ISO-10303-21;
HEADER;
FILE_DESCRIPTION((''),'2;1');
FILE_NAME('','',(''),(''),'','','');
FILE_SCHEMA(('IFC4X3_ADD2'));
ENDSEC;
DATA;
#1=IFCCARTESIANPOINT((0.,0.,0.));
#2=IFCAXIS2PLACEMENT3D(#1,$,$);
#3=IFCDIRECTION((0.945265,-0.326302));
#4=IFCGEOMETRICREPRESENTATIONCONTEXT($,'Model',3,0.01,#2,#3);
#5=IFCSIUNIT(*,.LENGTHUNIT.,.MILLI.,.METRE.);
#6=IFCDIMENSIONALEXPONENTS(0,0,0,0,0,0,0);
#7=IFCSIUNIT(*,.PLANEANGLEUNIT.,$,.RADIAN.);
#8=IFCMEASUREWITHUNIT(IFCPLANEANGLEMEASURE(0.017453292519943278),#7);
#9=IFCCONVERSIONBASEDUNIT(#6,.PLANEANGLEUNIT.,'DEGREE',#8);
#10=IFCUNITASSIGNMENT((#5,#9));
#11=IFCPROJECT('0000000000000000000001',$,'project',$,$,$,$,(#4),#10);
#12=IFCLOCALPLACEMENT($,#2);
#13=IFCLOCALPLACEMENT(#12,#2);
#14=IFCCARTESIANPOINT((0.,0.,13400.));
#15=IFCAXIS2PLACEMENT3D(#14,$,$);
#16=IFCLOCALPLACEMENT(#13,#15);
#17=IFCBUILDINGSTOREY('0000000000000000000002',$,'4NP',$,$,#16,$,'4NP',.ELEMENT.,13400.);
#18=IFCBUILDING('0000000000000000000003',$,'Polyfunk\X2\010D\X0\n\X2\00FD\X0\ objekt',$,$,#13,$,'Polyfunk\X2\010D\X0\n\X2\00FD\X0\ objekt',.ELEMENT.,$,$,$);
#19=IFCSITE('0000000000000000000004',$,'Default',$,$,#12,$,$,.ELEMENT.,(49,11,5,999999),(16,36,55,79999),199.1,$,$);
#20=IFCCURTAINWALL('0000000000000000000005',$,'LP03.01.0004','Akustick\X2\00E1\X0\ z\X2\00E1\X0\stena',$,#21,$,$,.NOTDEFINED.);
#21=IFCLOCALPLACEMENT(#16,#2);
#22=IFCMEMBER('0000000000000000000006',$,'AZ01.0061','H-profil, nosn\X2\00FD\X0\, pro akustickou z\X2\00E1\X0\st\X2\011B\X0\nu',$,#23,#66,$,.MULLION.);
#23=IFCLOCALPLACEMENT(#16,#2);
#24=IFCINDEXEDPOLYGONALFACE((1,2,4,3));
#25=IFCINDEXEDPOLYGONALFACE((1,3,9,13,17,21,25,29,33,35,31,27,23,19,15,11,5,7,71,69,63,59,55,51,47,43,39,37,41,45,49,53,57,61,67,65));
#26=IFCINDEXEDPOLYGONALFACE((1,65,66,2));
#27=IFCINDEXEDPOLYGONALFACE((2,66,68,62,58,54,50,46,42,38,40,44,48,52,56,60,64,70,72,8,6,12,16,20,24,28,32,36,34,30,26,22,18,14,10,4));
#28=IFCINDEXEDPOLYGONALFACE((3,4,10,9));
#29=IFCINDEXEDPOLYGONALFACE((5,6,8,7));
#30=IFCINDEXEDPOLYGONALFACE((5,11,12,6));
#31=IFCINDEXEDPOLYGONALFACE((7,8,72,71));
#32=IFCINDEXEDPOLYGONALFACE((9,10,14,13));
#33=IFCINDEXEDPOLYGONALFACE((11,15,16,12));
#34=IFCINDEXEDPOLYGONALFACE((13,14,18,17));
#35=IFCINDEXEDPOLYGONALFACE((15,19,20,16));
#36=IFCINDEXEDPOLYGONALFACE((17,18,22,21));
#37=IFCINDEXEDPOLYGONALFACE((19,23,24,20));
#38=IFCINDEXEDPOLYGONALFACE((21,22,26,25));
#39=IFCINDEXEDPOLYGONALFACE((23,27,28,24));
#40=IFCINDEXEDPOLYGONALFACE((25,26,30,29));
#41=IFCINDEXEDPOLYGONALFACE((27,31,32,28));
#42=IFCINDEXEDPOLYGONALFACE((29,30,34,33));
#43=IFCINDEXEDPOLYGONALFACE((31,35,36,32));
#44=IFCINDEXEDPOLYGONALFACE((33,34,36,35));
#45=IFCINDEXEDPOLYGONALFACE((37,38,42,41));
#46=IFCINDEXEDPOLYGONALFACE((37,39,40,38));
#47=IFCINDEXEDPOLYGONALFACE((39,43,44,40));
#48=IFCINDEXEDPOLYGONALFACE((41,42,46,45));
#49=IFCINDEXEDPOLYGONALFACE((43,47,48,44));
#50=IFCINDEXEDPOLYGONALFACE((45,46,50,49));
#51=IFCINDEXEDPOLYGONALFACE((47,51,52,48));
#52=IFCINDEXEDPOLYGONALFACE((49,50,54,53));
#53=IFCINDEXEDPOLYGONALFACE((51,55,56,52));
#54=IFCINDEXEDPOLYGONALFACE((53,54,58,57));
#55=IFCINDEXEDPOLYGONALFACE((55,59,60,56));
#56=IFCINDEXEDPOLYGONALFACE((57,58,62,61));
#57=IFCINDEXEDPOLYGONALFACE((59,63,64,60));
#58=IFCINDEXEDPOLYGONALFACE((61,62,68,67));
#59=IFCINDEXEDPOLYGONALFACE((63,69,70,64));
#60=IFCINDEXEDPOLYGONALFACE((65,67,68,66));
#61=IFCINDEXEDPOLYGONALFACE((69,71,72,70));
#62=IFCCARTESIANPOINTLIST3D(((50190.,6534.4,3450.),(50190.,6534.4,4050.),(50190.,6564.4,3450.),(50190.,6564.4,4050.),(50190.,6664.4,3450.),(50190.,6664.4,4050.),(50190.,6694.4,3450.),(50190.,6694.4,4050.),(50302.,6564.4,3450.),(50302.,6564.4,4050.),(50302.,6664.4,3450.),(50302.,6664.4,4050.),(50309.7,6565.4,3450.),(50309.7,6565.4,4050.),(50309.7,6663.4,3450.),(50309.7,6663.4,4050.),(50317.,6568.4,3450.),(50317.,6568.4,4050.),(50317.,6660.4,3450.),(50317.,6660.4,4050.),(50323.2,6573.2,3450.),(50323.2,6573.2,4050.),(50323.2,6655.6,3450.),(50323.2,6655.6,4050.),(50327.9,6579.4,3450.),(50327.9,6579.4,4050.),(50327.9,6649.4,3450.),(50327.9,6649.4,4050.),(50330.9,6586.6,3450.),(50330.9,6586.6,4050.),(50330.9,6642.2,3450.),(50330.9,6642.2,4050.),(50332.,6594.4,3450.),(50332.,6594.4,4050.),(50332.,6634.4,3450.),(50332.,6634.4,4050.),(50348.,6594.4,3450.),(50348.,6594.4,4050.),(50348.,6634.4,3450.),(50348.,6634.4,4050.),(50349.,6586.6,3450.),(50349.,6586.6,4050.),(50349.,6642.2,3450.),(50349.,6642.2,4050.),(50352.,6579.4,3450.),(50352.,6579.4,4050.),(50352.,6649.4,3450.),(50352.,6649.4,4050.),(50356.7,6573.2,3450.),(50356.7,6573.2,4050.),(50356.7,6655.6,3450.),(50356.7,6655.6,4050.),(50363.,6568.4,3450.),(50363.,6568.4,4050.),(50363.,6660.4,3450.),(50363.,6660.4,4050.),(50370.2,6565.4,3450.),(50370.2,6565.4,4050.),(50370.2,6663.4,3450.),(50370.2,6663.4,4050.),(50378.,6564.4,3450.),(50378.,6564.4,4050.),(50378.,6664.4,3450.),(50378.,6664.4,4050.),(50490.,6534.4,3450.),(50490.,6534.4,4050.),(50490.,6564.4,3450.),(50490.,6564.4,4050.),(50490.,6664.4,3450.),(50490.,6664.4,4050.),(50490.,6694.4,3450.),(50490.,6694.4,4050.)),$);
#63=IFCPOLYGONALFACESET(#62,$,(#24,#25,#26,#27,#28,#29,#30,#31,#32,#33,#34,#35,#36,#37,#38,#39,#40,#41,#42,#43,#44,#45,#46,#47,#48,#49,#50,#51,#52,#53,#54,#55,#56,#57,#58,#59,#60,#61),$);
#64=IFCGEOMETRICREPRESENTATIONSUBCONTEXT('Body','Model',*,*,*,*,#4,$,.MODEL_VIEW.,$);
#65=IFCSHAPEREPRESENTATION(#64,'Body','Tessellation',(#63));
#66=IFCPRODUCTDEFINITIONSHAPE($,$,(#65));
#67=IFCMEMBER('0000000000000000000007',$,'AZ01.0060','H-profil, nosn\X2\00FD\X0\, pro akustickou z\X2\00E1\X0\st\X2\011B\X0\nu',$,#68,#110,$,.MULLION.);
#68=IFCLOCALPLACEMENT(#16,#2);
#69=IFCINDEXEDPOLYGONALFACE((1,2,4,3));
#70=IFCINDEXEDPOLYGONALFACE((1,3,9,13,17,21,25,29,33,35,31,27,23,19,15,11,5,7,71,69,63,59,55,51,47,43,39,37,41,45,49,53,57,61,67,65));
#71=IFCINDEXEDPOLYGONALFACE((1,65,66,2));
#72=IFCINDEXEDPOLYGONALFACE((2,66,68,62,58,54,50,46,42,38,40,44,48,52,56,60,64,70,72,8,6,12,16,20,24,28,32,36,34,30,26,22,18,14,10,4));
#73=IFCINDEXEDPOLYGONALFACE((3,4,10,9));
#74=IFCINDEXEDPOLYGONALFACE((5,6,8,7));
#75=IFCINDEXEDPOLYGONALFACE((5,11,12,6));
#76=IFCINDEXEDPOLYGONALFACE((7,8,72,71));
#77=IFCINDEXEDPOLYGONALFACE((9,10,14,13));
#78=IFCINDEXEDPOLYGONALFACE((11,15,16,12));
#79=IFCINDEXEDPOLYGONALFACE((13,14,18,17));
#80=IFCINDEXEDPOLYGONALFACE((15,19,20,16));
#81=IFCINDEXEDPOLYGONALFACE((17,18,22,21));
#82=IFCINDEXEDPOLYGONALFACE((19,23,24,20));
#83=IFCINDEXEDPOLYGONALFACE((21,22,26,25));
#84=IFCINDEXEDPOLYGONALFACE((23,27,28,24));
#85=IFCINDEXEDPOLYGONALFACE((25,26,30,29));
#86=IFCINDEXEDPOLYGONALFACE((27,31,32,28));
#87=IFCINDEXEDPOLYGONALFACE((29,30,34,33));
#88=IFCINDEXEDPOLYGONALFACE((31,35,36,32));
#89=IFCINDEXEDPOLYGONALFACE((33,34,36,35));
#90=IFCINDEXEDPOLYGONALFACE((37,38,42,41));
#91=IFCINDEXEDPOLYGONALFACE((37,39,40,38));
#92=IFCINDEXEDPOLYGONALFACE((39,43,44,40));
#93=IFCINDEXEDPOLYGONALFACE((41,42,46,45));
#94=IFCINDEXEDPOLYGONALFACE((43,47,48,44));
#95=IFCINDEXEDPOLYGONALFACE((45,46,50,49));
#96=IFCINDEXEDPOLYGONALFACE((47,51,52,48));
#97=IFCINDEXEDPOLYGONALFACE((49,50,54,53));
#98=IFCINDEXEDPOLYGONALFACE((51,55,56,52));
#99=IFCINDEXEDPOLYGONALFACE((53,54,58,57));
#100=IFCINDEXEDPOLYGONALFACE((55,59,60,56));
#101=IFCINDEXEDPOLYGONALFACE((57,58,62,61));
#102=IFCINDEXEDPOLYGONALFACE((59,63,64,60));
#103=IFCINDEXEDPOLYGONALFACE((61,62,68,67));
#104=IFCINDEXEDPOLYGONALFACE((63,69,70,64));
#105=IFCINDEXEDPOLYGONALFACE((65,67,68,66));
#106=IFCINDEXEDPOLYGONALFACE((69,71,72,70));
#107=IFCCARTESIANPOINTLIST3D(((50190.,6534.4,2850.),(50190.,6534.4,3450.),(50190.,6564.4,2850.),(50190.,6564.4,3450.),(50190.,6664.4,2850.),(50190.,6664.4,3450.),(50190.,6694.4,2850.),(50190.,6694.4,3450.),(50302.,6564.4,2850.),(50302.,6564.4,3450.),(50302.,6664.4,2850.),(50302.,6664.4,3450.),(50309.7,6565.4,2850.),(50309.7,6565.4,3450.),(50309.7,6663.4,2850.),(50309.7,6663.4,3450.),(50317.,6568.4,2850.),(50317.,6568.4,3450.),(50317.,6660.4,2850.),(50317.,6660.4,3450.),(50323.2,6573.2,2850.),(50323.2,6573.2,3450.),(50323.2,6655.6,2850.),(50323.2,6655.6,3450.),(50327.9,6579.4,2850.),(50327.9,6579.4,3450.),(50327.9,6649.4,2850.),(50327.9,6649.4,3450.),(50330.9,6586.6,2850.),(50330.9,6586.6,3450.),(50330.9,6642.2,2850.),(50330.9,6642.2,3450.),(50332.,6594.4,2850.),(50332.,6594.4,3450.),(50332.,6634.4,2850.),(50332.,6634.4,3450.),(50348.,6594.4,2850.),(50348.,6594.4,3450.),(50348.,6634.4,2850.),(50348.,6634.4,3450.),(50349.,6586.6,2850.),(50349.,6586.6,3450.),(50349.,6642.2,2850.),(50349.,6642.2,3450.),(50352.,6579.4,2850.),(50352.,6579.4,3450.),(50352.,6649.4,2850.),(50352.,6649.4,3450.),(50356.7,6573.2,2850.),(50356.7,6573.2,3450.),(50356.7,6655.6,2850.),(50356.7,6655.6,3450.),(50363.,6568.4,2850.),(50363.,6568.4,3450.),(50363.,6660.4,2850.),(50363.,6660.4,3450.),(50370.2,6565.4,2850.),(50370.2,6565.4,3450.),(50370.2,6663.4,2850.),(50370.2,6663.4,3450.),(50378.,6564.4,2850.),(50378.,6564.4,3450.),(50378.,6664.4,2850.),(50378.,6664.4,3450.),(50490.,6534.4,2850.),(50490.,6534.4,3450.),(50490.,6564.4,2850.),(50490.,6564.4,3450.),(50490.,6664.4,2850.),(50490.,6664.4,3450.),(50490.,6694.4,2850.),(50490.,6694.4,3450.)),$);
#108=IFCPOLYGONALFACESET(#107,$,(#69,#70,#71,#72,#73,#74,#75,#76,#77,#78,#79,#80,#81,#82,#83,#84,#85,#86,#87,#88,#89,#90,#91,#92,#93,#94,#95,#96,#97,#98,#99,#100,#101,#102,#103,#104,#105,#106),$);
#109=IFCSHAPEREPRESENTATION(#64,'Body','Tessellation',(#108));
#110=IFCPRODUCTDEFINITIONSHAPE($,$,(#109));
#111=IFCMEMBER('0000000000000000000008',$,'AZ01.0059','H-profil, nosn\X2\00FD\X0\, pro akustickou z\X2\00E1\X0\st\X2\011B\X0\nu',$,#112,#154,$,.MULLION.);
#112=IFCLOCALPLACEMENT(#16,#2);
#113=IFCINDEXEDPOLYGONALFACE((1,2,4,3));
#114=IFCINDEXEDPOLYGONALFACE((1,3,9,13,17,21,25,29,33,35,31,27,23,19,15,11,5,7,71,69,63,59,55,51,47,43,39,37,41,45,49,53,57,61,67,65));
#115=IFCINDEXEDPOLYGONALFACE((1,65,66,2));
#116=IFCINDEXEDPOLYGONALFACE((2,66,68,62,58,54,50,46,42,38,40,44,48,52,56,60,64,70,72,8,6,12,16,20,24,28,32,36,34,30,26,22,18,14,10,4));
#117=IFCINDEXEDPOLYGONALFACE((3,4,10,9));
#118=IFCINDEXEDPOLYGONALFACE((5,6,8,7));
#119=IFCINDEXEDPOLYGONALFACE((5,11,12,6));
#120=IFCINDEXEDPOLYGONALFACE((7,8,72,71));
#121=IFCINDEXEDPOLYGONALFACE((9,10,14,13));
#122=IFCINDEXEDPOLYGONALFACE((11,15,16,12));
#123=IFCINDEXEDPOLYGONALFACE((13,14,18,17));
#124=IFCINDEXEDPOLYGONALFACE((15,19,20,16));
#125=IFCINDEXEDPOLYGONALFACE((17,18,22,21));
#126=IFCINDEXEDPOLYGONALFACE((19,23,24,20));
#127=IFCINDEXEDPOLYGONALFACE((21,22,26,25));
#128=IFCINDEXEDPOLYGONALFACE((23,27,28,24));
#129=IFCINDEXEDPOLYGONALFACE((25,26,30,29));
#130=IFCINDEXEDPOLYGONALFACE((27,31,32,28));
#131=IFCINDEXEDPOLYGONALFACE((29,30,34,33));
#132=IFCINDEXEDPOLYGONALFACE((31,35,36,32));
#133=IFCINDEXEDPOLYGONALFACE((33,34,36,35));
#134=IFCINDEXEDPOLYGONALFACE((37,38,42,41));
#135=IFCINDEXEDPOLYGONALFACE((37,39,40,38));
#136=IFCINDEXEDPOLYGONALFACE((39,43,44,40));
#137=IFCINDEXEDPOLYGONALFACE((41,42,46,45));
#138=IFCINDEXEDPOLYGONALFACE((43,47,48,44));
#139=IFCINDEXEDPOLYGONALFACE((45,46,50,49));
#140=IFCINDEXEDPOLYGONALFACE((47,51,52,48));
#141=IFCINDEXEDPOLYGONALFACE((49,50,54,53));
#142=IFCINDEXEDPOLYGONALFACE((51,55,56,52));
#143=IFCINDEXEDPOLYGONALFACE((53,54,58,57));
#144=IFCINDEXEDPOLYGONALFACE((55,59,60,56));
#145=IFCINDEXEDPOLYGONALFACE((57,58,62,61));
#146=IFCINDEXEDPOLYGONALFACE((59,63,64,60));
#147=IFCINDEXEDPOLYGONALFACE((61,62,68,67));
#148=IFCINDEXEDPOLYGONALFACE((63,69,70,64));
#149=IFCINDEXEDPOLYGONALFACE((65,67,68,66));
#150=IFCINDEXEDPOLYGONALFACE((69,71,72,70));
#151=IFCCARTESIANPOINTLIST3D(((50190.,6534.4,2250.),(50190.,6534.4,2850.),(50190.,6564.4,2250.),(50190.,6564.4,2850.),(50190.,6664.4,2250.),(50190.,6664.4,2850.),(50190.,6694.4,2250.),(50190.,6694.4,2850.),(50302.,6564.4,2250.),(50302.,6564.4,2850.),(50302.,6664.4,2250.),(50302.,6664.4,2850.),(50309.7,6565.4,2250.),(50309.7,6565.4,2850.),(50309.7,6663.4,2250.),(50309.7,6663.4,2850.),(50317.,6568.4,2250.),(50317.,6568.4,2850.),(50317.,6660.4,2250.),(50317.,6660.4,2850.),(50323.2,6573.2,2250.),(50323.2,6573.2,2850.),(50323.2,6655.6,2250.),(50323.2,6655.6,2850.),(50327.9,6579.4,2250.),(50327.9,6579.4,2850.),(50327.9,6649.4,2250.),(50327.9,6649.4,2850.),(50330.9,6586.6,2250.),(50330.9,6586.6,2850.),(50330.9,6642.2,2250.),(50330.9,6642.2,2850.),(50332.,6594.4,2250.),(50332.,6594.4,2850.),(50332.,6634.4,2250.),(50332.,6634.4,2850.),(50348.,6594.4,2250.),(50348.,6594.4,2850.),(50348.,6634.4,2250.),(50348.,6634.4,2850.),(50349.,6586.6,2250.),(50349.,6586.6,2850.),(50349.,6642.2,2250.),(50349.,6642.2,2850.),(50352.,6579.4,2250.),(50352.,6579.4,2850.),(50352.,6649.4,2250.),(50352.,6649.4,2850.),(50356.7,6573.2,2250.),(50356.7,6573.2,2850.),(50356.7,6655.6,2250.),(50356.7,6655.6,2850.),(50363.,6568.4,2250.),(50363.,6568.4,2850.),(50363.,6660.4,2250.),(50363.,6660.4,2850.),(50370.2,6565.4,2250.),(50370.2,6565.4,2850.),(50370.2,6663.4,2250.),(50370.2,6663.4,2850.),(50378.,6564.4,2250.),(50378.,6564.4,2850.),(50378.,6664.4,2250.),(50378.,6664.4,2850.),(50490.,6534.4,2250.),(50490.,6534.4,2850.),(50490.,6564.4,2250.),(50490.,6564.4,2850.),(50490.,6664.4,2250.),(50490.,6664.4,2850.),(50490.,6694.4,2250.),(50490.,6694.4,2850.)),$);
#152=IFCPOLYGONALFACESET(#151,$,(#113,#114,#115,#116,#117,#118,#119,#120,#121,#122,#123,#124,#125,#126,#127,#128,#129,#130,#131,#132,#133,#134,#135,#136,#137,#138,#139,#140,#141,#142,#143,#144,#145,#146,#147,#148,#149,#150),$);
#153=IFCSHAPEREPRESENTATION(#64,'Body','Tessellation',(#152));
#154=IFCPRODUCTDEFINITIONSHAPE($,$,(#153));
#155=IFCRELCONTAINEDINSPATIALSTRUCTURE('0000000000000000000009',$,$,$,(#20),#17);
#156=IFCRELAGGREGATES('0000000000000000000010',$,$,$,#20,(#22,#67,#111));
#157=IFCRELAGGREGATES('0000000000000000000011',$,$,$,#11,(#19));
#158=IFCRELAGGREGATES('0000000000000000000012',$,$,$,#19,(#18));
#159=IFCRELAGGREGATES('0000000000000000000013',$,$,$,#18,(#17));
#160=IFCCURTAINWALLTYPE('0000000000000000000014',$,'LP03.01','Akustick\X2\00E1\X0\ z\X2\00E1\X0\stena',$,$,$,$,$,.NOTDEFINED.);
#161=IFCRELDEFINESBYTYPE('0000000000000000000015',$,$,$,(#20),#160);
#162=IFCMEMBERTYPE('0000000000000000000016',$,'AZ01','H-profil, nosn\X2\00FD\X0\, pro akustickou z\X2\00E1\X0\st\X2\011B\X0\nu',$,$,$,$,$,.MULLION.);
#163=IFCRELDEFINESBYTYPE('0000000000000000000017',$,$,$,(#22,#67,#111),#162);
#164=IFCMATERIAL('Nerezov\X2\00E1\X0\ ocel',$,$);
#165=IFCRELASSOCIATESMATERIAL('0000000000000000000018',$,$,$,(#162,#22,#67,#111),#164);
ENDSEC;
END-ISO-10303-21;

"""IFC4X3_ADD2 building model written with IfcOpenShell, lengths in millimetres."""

from ifc_helpers import new_model, entity, si_unit, converted_unit, direction, frame, frame_2d, origin, place, context, subcontext, project, spatial, polyline, circle_curve, parameter, trimmed, segment, composite_curve, outline, extrude, source, transform, mapped, material, material_profile, profile_set, profile_usage, type_object, element, aggregate, save


model = new_model("IFC4X3_ADD2")

# Units and contexts
model_context = context("Model", 3, precision=0.01, world=origin(), true_north=direction((0.945265, -0.326302)))
body_context = subcontext(model_context, "Body", "Model", "MODEL_VIEW")
ifc_project = project(units=[si_unit("LENGTHUNIT", "METRE", prefix="MILLI"), converted_unit("PLANEANGLEUNIT", "DEGREE", entity("IfcPlaneAngleMeasure", 0.017453292519943278), si_unit("PLANEANGLEUNIT", "RADIAN"), dimensions=[0, 0, 0, 0, 0, 0, 0])], contexts=[model_context])

# Site, building, storey
site_placement = place(None, origin())
site = spatial("IfcSite", under=ifc_project, at=site_placement, Name="Default", CompositionType="ELEMENT", RefLatitude=(49, 11, 5, 999999), RefLongitude=(16, 36, 55, 79999), RefElevation=199.1)
building_placement = place(site_placement, origin())
building = spatial("IfcBuilding", under=site, at=building_placement, Name="Polyfunkčný objekt", LongName="Polyfunkčný objekt", CompositionType="ELEMENT")
storey_placement = place(building_placement, frame((0.0, 0.0, 13400.0)))
storey = spatial("IfcBuildingStorey", under=building, at=storey_placement, Name="4NP", LongName="4NP", CompositionType="ELEMENT", Elevation=13400.0)

# Curtain wall, members
curtain_wall_type = type_object("IfcCurtainWallType", Name="LP03.01", Description="Akustická zástena", PredefinedType="NOTDEFINED")
curtain_wall_1_placement = place(storey_placement, frame((0.0, 0.0, -13400.0)))
curtain_wall_1 = element("IfcCurtainWall", 1, at=curtain_wall_1_placement, inside=storey, type_object=curtain_wall_type, Name="LP03.01.0004", Description="Akustická zástena", PredefinedType="NOTDEFINED")
ifc_material_1 = material(Name="Nerezová ocel")
ifc_material_profile = material_profile(ifc_material_1, outline(composite_curve([segment(polyline([(50.0, -150.0), (80.0, -150.0)]), True, "CONTINUOUS"), segment(polyline([(80.0, -150.0), (80.0, 150.0)]), True, "CONTINUOUS"), segment(polyline([(80.0, 150.0), (50.0, 150.0)]), True, "CONTINUOUS"), segment(polyline([(50.0, 150.0), (50.0, 38.0)]), True, "CONTINUOUS"), segment(trimmed(circle_curve(frame_2d((20.0, 38.0), x_axis=(0.0, 1.0)), 30.0), [parameter(180.0)], [parameter(270.0)], True, "PARAMETER"), False, "CONTINUOUS"), segment(polyline([(20.0, 8.0), (-20.0, 8.0)]), True, "CONTINUOUS"), segment(trimmed(circle_curve(frame_2d((-20.0, 38.0), x_axis=(0.0, 1.0)), 30.0), [parameter(90.0)], [parameter(180.0)], True, "PARAMETER"), False, "CONTINUOUS"), segment(polyline([(-50.0, 38.0), (-50.0, 150.0)]), True, "CONTINUOUS"), segment(polyline([(-50.0, 150.0), (-80.0, 150.0)]), True, "CONTINUOUS"), segment(polyline([(-80.0, 150.0), (-80.0, -150.0)]), True, "CONTINUOUS"), segment(polyline([(-80.0, -150.0), (-50.0, -150.0)]), True, "CONTINUOUS"), segment(polyline([(-50.0, -150.0), (-50.0, -38.0)]), True, "CONTINUOUS"), segment(trimmed(circle_curve(frame_2d((-20.0, -38.0), x_axis=(0.0, 1.0)), 30.0), [parameter(0.0)], [parameter(90.0)], True, "PARAMETER"), False, "CONTINUOUS"), segment(polyline([(-20.0, -8.0), (20.0, -8.0)]), True, "CONTINUOUS"), segment(trimmed(circle_curve(frame_2d((20.0, -38.0), x_axis=(0.0, 1.0)), 30.0), [parameter(270.0)], [parameter(0.0)], True, "PARAMETER"), False, "CONTINUOUS"), segment(polyline([(50.0, -38.0), (50.0, -150.0)]), True, "CONTINUOUS")], self_intersect=False)), Name="Profil zástena")
ifc_profile_set = profile_set([ifc_material_profile], Name="Profil zástena")
ifc_profile_usage = profile_usage(ifc_profile_set)
member_type = type_object("IfcMemberType", Name="AZ01", Description="H-profil, nosný, pro akustickou zástěnu", PredefinedType="MULLION", material=ifc_profile_set)
shared_shape_1 = source(origin(), body_context, "Body", "SweptSolid", [
    extrude(outline(composite_curve([segment(polyline([(-150.0, -50.0), (-150.0, -80.0)]), True, "CONTINUOUS"), segment(polyline([(-150.0, -80.0), (150.0, -80.0)]), True, "CONTINUOUS"), segment(polyline([(150.0, -80.0), (150.0, -50.0)]), True, "CONTINUOUS"), segment(polyline([(150.0, -50.0), (38.0, -50.0)]), True, "CONTINUOUS"), segment(trimmed(circle_curve(frame_2d((38.0, -20.0), x_axis=(1.0, 0.0)), 30.0), [parameter(180.0)], [parameter(270.0)], True, "PARAMETER"), False, "CONTINUOUS"), segment(polyline([(8.0, -20.0), (8.0, 20.0)]), True, "CONTINUOUS"), segment(trimmed(circle_curve(frame_2d((38.0, 20.0), x_axis=(1.0, 0.0)), 30.0), [parameter(90.0)], [parameter(180.0)], True, "PARAMETER"), False, "CONTINUOUS"), segment(polyline([(38.0, 50.0), (150.0, 50.0)]), True, "CONTINUOUS"), segment(polyline([(150.0, 50.0), (150.0, 80.0)]), True, "CONTINUOUS"), segment(polyline([(150.0, 80.0), (-150.0, 80.0)]), True, "CONTINUOUS"), segment(polyline([(-150.0, 80.0), (-150.0, 50.0)]), True, "CONTINUOUS"), segment(polyline([(-150.0, 50.0), (-38.0, 50.0)]), True, "CONTINUOUS"), segment(trimmed(circle_curve(frame_2d((-38.0, 20.0), x_axis=(1.0, 0.0)), 30.0), [parameter(0.0)], [parameter(90.0)], True, "PARAMETER"), False, "CONTINUOUS"), segment(polyline([(-8.0, 20.0), (-8.0, -20.0)]), True, "CONTINUOUS"), segment(trimmed(circle_curve(frame_2d((-38.0, -20.0), x_axis=(1.0, 0.0)), 30.0), [parameter(270.0)], [parameter(0.0)], True, "PARAMETER"), False, "CONTINUOUS"), segment(polyline([(-38.0, -50.0), (-150.0, -50.0)]), True, "CONTINUOUS")], self_intersect=False)), frame((-150.0, 0.0, -600.0), z_axis=(0.0, 0.0, -1.0), x_axis=(-1.0, 0.0, 0.0)), (0.0, 0.0, -1.0), 600.0),
])
member_1_placement = place(curtain_wall_1_placement, frame((50190.0, 6614.4, 17450.0), z_axis=(0.0, 0.0, 1.0), x_axis=(-1.0, 0.0, 0.0)))
member_1 = element("IfcMember", 2, at=member_1_placement, type_object=member_type, material=ifc_profile_usage, Name="AZ01.0061", Description="H-profil, nosný, pro akustickou zástěnu", PredefinedType="MULLION", context=body_context, shape_type="MappedRepresentation", body=[
    mapped(shared_shape_1, transform((0.0, 0.0, 0.0), scale=1.0)),
])
member_2_placement = place(curtain_wall_1_placement, frame((50190.0, 6614.4, 16850.0), z_axis=(0.0, 0.0, 1.0), x_axis=(-1.0, 0.0, 0.0)))
member_2 = element("IfcMember", 3, at=member_2_placement, type_object=member_type, material=ifc_profile_usage, Name="AZ01.0060", Description="H-profil, nosný, pro akustickou zástěnu", PredefinedType="MULLION", context=body_context, shape_type="MappedRepresentation", body=[
    mapped(shared_shape_1, transform((0.0, 0.0, 0.0), scale=1.0)),
])
member_3_placement = place(curtain_wall_1_placement, frame((50190.0, 6614.4, 16250.0), z_axis=(0.0, 0.0, 1.0), x_axis=(-1.0, 0.0, 0.0)))
member_3 = element("IfcMember", 4, at=member_3_placement, type_object=member_type, material=ifc_profile_usage, Name="AZ01.0059", Description="H-profil, nosný, pro akustickou zástěnu", PredefinedType="MULLION", context=body_context, shape_type="MappedRepresentation", body=[
    mapped(shared_shape_1, transform((0.0, 0.0, 0.0), scale=1.0)),
])

aggregate(curtain_wall_1, [member_1, member_2, member_3])

save(model, "model.ifc")
